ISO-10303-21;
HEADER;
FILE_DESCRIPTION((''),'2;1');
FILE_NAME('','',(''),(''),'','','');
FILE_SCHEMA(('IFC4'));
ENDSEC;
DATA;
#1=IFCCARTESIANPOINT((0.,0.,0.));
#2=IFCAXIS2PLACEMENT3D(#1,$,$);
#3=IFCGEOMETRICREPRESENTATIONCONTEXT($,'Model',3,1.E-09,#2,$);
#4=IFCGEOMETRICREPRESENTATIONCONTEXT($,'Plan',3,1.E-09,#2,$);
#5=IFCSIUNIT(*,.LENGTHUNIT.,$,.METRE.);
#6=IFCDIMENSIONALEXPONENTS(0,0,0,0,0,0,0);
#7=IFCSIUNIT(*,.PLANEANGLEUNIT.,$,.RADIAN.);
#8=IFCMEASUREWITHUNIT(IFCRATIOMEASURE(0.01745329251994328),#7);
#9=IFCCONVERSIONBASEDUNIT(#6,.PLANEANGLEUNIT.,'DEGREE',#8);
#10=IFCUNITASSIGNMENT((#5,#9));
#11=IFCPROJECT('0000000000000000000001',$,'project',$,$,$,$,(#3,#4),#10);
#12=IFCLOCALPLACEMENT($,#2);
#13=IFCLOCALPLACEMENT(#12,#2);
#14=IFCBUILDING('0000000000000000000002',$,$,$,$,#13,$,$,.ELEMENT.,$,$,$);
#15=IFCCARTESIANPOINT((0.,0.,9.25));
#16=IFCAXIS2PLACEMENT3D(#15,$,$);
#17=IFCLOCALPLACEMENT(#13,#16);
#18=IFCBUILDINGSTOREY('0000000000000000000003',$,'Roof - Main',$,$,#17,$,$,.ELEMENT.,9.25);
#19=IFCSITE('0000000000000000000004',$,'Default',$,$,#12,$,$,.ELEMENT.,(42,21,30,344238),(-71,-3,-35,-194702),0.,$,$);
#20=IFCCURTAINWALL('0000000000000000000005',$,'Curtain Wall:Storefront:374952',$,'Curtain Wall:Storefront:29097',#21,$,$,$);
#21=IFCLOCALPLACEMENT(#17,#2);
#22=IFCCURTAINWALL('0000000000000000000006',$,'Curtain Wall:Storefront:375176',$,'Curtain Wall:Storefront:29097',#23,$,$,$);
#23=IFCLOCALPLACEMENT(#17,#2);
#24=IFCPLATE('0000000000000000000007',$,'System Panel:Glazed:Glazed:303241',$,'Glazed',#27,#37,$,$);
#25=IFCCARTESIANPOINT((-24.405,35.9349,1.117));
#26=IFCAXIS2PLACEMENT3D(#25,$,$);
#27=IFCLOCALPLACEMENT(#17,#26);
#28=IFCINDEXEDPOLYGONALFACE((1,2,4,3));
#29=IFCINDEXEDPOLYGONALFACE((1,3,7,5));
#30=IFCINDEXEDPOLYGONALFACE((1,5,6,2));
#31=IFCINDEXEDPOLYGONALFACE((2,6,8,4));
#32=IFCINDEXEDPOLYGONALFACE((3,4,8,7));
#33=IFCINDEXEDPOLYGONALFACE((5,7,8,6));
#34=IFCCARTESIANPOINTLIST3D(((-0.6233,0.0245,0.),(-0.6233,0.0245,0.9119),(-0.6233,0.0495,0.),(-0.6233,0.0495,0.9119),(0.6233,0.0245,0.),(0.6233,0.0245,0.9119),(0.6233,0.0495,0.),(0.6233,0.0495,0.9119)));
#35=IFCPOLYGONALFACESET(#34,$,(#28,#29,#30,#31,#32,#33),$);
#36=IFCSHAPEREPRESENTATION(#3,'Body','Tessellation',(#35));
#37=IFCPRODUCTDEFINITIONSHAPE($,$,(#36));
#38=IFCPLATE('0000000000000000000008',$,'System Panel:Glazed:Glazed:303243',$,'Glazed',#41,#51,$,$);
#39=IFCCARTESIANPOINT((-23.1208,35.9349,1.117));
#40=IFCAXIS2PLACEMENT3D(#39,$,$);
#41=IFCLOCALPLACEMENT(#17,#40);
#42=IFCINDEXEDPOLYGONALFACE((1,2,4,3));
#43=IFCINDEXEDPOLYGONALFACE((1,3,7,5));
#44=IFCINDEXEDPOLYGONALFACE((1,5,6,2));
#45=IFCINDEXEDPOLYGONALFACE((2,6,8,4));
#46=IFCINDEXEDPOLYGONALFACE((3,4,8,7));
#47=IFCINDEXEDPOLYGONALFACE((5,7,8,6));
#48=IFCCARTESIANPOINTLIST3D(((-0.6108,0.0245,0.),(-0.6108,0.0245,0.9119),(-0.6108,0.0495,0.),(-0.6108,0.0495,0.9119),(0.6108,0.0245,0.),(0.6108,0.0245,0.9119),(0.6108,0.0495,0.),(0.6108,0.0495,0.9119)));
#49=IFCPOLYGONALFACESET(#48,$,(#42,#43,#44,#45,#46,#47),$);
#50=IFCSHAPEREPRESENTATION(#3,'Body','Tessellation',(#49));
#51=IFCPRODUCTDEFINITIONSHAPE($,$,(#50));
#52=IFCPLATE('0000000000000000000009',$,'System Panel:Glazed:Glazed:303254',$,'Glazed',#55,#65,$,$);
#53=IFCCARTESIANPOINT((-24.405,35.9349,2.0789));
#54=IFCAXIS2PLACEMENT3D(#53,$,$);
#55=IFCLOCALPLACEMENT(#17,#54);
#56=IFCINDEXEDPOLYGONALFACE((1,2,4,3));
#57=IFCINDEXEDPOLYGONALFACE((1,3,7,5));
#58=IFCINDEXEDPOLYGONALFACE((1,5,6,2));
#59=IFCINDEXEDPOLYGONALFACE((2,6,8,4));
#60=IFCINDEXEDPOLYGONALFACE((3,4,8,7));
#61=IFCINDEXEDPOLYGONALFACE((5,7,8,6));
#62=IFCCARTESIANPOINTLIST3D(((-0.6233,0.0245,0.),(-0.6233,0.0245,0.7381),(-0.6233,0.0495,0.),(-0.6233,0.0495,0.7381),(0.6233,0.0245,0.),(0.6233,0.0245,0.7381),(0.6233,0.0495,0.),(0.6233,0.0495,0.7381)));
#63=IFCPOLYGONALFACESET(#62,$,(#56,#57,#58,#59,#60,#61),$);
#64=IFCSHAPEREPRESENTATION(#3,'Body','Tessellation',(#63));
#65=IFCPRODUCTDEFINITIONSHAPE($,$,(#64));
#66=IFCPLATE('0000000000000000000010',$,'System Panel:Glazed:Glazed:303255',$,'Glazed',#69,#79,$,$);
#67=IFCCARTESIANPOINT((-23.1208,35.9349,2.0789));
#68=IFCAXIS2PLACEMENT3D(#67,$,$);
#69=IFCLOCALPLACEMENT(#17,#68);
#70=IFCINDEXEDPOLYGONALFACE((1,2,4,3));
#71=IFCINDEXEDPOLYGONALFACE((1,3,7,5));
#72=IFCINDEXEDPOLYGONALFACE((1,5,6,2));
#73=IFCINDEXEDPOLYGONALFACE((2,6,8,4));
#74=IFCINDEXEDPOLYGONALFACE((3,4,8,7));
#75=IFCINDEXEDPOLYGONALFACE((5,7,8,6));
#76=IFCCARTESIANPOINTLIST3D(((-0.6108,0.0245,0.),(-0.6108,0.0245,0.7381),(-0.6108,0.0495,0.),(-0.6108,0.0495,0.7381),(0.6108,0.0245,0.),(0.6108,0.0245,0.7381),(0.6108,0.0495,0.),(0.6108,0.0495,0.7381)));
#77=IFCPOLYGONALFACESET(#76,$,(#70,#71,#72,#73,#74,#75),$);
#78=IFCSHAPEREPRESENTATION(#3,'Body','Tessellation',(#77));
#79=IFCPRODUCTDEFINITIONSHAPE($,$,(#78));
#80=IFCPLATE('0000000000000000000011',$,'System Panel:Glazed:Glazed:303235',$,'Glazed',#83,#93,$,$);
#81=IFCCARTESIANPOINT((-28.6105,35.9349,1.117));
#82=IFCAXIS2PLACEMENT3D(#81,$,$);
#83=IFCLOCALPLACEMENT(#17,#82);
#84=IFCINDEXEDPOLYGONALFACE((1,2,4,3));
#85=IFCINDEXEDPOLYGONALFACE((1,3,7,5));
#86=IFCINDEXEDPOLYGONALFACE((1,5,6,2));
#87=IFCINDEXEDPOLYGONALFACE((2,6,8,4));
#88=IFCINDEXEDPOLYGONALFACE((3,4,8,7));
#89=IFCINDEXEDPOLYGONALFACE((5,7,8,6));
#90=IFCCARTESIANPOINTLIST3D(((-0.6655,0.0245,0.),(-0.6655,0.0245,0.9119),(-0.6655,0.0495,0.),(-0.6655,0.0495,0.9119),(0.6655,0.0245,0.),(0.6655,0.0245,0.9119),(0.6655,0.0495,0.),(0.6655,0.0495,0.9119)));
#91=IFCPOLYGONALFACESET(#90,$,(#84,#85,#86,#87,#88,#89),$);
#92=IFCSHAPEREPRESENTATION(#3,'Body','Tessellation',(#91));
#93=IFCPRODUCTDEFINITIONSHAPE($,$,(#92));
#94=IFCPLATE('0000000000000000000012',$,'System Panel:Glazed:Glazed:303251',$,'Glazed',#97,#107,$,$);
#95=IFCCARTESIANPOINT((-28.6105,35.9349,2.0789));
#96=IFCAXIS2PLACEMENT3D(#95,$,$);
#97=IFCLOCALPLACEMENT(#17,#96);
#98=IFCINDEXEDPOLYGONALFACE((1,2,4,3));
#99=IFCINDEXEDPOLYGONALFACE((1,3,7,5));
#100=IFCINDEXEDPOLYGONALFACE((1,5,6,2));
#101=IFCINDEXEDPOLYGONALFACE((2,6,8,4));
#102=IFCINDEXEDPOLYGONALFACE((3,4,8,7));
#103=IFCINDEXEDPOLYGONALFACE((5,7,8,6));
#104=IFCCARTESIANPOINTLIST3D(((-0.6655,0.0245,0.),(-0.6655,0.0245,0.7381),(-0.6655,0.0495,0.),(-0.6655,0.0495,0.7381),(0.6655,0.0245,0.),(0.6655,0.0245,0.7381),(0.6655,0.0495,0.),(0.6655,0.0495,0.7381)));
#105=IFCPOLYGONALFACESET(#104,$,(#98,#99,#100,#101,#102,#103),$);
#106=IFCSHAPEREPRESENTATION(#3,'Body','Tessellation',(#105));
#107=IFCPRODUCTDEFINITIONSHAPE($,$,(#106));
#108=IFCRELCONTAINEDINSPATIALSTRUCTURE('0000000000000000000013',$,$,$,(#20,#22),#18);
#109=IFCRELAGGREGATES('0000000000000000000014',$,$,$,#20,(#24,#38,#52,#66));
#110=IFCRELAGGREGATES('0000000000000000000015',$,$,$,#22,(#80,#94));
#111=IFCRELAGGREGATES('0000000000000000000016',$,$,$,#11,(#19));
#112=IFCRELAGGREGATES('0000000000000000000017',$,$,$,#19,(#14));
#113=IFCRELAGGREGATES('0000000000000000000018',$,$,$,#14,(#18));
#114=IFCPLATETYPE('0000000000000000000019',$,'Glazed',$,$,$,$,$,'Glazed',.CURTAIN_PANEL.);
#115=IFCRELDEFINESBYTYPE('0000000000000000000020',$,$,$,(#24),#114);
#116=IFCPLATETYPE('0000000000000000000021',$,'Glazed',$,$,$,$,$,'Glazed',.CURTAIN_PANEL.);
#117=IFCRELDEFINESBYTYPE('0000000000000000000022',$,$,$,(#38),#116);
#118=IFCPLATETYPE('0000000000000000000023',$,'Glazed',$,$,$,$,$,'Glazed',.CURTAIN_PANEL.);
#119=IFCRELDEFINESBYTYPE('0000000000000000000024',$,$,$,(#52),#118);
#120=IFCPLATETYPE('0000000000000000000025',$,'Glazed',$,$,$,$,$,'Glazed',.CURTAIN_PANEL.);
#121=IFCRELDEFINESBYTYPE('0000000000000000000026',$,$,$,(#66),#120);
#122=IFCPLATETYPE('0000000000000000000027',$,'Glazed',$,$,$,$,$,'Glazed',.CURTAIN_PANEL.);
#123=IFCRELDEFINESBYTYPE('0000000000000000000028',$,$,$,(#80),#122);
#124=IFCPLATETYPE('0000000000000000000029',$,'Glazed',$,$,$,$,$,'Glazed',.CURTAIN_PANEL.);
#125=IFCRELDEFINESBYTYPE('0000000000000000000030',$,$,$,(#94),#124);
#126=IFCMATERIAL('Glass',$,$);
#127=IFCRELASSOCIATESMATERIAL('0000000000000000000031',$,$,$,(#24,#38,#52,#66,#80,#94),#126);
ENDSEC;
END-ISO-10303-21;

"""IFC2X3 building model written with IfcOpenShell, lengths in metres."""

from ifc_helpers import new_model, entity, si_unit, converted_unit, frame, origin, origin_2d_with_axis, place, context, project, spatial, rectangle, extrude, source, transform, mapped, material, type_object, type_shapes, element, aggregate, save


model = new_model("IFC2X3")

# Units and contexts
model_context = context("Model", 3, precision=1e-09, world=origin())
plan_context = context("Plan", 3, precision=1e-09, world=origin())
ifc_project = project(units=[si_unit("LENGTHUNIT", "METRE"), converted_unit("PLANEANGLEUNIT", "DEGREE", entity("IfcRatioMeasure", 0.01745329251994328), si_unit("PLANEANGLEUNIT", "RADIAN"), dimensions=[0, 0, 0, 0, 0, 0, 0])], contexts=[model_context, plan_context])

# Site, building, storey
site_placement = place(None, origin())
site = spatial("IfcSite", under=ifc_project, at=site_placement, Name="Default", CompositionType="ELEMENT", RefLatitude=(42, 21, 30, 344238), RefLongitude=(-71, -3, -35, -194702), RefElevation=0.0)
building_placement = place(site_placement, origin())
building = spatial("IfcBuilding", under=site, at=building_placement, CompositionType="ELEMENT")
storey_placement = place(building_placement, frame((0.0, 0.0, 9.25)))
storey = spatial("IfcBuildingStorey", under=building, at=storey_placement, Name="Roof - Main", CompositionType="ELEMENT", Elevation=9.25)

# Curtain wall
curtain_wall_1_placement = place(storey_placement, origin())
curtain_wall_1 = element("IfcCurtainWall", 1, at=curtain_wall_1_placement, inside=storey, Name="Curtain Wall:Storefront:374952", ObjectType="Curtain Wall:Storefront:29097")

# Curtain wall
curtain_wall_2_placement = place(storey_placement, origin())
curtain_wall_2 = element("IfcCurtainWall", 2, at=curtain_wall_2_placement, inside=storey, Name="Curtain Wall:Storefront:375176", ObjectType="Curtain Wall:Storefront:29097")

# Plates
ifc_material_1 = material(Name="Glass")
plate_type_1 = type_object("IfcPlateType", Name="Glazed", ElementType="Glazed", PredefinedType="CURTAIN_PANEL")
shared_shape_1 = source(origin(), model_context, "Body", "SweptSolid", [
    extrude(rectangle(XDim=0.025, YDim=1.2467, at=origin_2d_with_axis()), frame((0.0, 0.037, 0.0), z_axis=(0.0, 0.0, 1.0), x_axis=(0.0, 1.0, 0.0)), (0.0, 0.0, 1.0), 0.9119),
])
type_shapes(plate_type_1, [shared_shape_1])
plate_1_placement = place(storey_placement, frame((-24.405, 35.9349, 1.117)))
plate_1 = element("IfcPlate", 3, at=plate_1_placement, type_object=plate_type_1, material=ifc_material_1, Name="System Panel:Glazed:Glazed:303241", ObjectType="Glazed", context=model_context, shape_type="MappedRepresentation", body=[
    mapped(shared_shape_1, transform((0.0, 0.0, 0.0), scale=1.0)),
])
plate_type_2 = type_object("IfcPlateType", Name="Glazed", ElementType="Glazed", PredefinedType="CURTAIN_PANEL")
shared_shape_2 = source(origin(), model_context, "Body", "SweptSolid", [
    extrude(rectangle(XDim=0.025, YDim=1.2217, at=origin_2d_with_axis()), frame((0.0, 0.037, 0.0), z_axis=(0.0, 0.0, 1.0), x_axis=(0.0, 1.0, 0.0)), (0.0, 0.0, 1.0), 0.9119),
])
type_shapes(plate_type_2, [shared_shape_2])
plate_2_placement = place(storey_placement, frame((-23.1208, 35.9349, 1.117)))
plate_2 = element("IfcPlate", 4, at=plate_2_placement, type_object=plate_type_2, material=ifc_material_1, Name="System Panel:Glazed:Glazed:303243", ObjectType="Glazed", context=model_context, shape_type="MappedRepresentation", body=[
    mapped(shared_shape_2, transform((0.0, 0.0, 0.0), scale=1.0)),
])
plate_type_3 = type_object("IfcPlateType", Name="Glazed", ElementType="Glazed", PredefinedType="CURTAIN_PANEL")
shared_shape_3 = source(origin(), model_context, "Body", "SweptSolid", [
    extrude(rectangle(XDim=0.025, YDim=1.2467, at=origin_2d_with_axis()), frame((0.0, 0.037, 0.0), z_axis=(0.0, 0.0, 1.0), x_axis=(0.0, 1.0, 0.0)), (0.0, 0.0, 1.0), 0.7381),
])
type_shapes(plate_type_3, [shared_shape_3])
plate_3_placement = place(storey_placement, frame((-24.405, 35.9349, 2.0789)))
plate_3 = element("IfcPlate", 5, at=plate_3_placement, type_object=plate_type_3, material=ifc_material_1, Name="System Panel:Glazed:Glazed:303254", ObjectType="Glazed", context=model_context, shape_type="MappedRepresentation", body=[
    mapped(shared_shape_3, transform((0.0, 0.0, 0.0), scale=1.0)),
])
plate_type_4 = type_object("IfcPlateType", Name="Glazed", ElementType="Glazed", PredefinedType="CURTAIN_PANEL")
shared_shape_4 = source(origin(), model_context, "Body", "SweptSolid", [
    extrude(rectangle(XDim=0.025, YDim=1.2217, at=origin_2d_with_axis()), frame((0.0, 0.037, 0.0), z_axis=(0.0, 0.0, 1.0), x_axis=(0.0, 1.0, 0.0)), (0.0, 0.0, 1.0), 0.7381),
])
type_shapes(plate_type_4, [shared_shape_4])
plate_4_placement = place(storey_placement, frame((-23.1208, 35.9349, 2.0789)))
plate_4 = element("IfcPlate", 6, at=plate_4_placement, type_object=plate_type_4, material=ifc_material_1, Name="System Panel:Glazed:Glazed:303255", ObjectType="Glazed", context=model_context, shape_type="MappedRepresentation", body=[
    mapped(shared_shape_4, transform((0.0, 0.0, 0.0), scale=1.0)),
])
aggregate(curtain_wall_1, [plate_1, plate_2, plate_3, plate_4])
plate_type_5 = type_object("IfcPlateType", Name="Glazed", ElementType="Glazed", PredefinedType="CURTAIN_PANEL")
shared_shape_5 = source(origin(), model_context, "Body", "SweptSolid", [
    extrude(rectangle(XDim=0.025, YDim=1.331, at=origin_2d_with_axis()), frame((0.0, 0.037, 0.0), z_axis=(0.0, 0.0, 1.0), x_axis=(0.0, 1.0, 0.0)), (0.0, 0.0, 1.0), 0.9119),
])
type_shapes(plate_type_5, [shared_shape_5])
plate_5_placement = place(storey_placement, frame((-28.6105, 35.9349, 1.117)))
plate_5 = element("IfcPlate", 7, at=plate_5_placement, type_object=plate_type_5, material=ifc_material_1, Name="System Panel:Glazed:Glazed:303235", ObjectType="Glazed", context=model_context, shape_type="MappedRepresentation", body=[
    mapped(shared_shape_5, transform((0.0, 0.0, 0.0), scale=1.0)),
])
plate_type_6 = type_object("IfcPlateType", Name="Glazed", ElementType="Glazed", PredefinedType="CURTAIN_PANEL")
shared_shape_6 = source(origin(), model_context, "Body", "SweptSolid", [
    extrude(rectangle(XDim=0.025, YDim=1.331, at=origin_2d_with_axis()), frame((0.0, 0.037, 0.0), z_axis=(0.0, 0.0, 1.0), x_axis=(0.0, 1.0, 0.0)), (0.0, 0.0, 1.0), 0.7381),
])
type_shapes(plate_type_6, [shared_shape_6])
plate_6_placement = place(storey_placement, frame((-28.6105, 35.9349, 2.0789)))
plate_6 = element("IfcPlate", 8, at=plate_6_placement, type_object=plate_type_6, material=ifc_material_1, Name="System Panel:Glazed:Glazed:303251", ObjectType="Glazed", context=model_context, shape_type="MappedRepresentation", body=[
    mapped(shared_shape_6, transform((0.0, 0.0, 0.0), scale=1.0)),
])
aggregate(curtain_wall_2, [plate_5, plate_6])

save(model, "model.ifc")
